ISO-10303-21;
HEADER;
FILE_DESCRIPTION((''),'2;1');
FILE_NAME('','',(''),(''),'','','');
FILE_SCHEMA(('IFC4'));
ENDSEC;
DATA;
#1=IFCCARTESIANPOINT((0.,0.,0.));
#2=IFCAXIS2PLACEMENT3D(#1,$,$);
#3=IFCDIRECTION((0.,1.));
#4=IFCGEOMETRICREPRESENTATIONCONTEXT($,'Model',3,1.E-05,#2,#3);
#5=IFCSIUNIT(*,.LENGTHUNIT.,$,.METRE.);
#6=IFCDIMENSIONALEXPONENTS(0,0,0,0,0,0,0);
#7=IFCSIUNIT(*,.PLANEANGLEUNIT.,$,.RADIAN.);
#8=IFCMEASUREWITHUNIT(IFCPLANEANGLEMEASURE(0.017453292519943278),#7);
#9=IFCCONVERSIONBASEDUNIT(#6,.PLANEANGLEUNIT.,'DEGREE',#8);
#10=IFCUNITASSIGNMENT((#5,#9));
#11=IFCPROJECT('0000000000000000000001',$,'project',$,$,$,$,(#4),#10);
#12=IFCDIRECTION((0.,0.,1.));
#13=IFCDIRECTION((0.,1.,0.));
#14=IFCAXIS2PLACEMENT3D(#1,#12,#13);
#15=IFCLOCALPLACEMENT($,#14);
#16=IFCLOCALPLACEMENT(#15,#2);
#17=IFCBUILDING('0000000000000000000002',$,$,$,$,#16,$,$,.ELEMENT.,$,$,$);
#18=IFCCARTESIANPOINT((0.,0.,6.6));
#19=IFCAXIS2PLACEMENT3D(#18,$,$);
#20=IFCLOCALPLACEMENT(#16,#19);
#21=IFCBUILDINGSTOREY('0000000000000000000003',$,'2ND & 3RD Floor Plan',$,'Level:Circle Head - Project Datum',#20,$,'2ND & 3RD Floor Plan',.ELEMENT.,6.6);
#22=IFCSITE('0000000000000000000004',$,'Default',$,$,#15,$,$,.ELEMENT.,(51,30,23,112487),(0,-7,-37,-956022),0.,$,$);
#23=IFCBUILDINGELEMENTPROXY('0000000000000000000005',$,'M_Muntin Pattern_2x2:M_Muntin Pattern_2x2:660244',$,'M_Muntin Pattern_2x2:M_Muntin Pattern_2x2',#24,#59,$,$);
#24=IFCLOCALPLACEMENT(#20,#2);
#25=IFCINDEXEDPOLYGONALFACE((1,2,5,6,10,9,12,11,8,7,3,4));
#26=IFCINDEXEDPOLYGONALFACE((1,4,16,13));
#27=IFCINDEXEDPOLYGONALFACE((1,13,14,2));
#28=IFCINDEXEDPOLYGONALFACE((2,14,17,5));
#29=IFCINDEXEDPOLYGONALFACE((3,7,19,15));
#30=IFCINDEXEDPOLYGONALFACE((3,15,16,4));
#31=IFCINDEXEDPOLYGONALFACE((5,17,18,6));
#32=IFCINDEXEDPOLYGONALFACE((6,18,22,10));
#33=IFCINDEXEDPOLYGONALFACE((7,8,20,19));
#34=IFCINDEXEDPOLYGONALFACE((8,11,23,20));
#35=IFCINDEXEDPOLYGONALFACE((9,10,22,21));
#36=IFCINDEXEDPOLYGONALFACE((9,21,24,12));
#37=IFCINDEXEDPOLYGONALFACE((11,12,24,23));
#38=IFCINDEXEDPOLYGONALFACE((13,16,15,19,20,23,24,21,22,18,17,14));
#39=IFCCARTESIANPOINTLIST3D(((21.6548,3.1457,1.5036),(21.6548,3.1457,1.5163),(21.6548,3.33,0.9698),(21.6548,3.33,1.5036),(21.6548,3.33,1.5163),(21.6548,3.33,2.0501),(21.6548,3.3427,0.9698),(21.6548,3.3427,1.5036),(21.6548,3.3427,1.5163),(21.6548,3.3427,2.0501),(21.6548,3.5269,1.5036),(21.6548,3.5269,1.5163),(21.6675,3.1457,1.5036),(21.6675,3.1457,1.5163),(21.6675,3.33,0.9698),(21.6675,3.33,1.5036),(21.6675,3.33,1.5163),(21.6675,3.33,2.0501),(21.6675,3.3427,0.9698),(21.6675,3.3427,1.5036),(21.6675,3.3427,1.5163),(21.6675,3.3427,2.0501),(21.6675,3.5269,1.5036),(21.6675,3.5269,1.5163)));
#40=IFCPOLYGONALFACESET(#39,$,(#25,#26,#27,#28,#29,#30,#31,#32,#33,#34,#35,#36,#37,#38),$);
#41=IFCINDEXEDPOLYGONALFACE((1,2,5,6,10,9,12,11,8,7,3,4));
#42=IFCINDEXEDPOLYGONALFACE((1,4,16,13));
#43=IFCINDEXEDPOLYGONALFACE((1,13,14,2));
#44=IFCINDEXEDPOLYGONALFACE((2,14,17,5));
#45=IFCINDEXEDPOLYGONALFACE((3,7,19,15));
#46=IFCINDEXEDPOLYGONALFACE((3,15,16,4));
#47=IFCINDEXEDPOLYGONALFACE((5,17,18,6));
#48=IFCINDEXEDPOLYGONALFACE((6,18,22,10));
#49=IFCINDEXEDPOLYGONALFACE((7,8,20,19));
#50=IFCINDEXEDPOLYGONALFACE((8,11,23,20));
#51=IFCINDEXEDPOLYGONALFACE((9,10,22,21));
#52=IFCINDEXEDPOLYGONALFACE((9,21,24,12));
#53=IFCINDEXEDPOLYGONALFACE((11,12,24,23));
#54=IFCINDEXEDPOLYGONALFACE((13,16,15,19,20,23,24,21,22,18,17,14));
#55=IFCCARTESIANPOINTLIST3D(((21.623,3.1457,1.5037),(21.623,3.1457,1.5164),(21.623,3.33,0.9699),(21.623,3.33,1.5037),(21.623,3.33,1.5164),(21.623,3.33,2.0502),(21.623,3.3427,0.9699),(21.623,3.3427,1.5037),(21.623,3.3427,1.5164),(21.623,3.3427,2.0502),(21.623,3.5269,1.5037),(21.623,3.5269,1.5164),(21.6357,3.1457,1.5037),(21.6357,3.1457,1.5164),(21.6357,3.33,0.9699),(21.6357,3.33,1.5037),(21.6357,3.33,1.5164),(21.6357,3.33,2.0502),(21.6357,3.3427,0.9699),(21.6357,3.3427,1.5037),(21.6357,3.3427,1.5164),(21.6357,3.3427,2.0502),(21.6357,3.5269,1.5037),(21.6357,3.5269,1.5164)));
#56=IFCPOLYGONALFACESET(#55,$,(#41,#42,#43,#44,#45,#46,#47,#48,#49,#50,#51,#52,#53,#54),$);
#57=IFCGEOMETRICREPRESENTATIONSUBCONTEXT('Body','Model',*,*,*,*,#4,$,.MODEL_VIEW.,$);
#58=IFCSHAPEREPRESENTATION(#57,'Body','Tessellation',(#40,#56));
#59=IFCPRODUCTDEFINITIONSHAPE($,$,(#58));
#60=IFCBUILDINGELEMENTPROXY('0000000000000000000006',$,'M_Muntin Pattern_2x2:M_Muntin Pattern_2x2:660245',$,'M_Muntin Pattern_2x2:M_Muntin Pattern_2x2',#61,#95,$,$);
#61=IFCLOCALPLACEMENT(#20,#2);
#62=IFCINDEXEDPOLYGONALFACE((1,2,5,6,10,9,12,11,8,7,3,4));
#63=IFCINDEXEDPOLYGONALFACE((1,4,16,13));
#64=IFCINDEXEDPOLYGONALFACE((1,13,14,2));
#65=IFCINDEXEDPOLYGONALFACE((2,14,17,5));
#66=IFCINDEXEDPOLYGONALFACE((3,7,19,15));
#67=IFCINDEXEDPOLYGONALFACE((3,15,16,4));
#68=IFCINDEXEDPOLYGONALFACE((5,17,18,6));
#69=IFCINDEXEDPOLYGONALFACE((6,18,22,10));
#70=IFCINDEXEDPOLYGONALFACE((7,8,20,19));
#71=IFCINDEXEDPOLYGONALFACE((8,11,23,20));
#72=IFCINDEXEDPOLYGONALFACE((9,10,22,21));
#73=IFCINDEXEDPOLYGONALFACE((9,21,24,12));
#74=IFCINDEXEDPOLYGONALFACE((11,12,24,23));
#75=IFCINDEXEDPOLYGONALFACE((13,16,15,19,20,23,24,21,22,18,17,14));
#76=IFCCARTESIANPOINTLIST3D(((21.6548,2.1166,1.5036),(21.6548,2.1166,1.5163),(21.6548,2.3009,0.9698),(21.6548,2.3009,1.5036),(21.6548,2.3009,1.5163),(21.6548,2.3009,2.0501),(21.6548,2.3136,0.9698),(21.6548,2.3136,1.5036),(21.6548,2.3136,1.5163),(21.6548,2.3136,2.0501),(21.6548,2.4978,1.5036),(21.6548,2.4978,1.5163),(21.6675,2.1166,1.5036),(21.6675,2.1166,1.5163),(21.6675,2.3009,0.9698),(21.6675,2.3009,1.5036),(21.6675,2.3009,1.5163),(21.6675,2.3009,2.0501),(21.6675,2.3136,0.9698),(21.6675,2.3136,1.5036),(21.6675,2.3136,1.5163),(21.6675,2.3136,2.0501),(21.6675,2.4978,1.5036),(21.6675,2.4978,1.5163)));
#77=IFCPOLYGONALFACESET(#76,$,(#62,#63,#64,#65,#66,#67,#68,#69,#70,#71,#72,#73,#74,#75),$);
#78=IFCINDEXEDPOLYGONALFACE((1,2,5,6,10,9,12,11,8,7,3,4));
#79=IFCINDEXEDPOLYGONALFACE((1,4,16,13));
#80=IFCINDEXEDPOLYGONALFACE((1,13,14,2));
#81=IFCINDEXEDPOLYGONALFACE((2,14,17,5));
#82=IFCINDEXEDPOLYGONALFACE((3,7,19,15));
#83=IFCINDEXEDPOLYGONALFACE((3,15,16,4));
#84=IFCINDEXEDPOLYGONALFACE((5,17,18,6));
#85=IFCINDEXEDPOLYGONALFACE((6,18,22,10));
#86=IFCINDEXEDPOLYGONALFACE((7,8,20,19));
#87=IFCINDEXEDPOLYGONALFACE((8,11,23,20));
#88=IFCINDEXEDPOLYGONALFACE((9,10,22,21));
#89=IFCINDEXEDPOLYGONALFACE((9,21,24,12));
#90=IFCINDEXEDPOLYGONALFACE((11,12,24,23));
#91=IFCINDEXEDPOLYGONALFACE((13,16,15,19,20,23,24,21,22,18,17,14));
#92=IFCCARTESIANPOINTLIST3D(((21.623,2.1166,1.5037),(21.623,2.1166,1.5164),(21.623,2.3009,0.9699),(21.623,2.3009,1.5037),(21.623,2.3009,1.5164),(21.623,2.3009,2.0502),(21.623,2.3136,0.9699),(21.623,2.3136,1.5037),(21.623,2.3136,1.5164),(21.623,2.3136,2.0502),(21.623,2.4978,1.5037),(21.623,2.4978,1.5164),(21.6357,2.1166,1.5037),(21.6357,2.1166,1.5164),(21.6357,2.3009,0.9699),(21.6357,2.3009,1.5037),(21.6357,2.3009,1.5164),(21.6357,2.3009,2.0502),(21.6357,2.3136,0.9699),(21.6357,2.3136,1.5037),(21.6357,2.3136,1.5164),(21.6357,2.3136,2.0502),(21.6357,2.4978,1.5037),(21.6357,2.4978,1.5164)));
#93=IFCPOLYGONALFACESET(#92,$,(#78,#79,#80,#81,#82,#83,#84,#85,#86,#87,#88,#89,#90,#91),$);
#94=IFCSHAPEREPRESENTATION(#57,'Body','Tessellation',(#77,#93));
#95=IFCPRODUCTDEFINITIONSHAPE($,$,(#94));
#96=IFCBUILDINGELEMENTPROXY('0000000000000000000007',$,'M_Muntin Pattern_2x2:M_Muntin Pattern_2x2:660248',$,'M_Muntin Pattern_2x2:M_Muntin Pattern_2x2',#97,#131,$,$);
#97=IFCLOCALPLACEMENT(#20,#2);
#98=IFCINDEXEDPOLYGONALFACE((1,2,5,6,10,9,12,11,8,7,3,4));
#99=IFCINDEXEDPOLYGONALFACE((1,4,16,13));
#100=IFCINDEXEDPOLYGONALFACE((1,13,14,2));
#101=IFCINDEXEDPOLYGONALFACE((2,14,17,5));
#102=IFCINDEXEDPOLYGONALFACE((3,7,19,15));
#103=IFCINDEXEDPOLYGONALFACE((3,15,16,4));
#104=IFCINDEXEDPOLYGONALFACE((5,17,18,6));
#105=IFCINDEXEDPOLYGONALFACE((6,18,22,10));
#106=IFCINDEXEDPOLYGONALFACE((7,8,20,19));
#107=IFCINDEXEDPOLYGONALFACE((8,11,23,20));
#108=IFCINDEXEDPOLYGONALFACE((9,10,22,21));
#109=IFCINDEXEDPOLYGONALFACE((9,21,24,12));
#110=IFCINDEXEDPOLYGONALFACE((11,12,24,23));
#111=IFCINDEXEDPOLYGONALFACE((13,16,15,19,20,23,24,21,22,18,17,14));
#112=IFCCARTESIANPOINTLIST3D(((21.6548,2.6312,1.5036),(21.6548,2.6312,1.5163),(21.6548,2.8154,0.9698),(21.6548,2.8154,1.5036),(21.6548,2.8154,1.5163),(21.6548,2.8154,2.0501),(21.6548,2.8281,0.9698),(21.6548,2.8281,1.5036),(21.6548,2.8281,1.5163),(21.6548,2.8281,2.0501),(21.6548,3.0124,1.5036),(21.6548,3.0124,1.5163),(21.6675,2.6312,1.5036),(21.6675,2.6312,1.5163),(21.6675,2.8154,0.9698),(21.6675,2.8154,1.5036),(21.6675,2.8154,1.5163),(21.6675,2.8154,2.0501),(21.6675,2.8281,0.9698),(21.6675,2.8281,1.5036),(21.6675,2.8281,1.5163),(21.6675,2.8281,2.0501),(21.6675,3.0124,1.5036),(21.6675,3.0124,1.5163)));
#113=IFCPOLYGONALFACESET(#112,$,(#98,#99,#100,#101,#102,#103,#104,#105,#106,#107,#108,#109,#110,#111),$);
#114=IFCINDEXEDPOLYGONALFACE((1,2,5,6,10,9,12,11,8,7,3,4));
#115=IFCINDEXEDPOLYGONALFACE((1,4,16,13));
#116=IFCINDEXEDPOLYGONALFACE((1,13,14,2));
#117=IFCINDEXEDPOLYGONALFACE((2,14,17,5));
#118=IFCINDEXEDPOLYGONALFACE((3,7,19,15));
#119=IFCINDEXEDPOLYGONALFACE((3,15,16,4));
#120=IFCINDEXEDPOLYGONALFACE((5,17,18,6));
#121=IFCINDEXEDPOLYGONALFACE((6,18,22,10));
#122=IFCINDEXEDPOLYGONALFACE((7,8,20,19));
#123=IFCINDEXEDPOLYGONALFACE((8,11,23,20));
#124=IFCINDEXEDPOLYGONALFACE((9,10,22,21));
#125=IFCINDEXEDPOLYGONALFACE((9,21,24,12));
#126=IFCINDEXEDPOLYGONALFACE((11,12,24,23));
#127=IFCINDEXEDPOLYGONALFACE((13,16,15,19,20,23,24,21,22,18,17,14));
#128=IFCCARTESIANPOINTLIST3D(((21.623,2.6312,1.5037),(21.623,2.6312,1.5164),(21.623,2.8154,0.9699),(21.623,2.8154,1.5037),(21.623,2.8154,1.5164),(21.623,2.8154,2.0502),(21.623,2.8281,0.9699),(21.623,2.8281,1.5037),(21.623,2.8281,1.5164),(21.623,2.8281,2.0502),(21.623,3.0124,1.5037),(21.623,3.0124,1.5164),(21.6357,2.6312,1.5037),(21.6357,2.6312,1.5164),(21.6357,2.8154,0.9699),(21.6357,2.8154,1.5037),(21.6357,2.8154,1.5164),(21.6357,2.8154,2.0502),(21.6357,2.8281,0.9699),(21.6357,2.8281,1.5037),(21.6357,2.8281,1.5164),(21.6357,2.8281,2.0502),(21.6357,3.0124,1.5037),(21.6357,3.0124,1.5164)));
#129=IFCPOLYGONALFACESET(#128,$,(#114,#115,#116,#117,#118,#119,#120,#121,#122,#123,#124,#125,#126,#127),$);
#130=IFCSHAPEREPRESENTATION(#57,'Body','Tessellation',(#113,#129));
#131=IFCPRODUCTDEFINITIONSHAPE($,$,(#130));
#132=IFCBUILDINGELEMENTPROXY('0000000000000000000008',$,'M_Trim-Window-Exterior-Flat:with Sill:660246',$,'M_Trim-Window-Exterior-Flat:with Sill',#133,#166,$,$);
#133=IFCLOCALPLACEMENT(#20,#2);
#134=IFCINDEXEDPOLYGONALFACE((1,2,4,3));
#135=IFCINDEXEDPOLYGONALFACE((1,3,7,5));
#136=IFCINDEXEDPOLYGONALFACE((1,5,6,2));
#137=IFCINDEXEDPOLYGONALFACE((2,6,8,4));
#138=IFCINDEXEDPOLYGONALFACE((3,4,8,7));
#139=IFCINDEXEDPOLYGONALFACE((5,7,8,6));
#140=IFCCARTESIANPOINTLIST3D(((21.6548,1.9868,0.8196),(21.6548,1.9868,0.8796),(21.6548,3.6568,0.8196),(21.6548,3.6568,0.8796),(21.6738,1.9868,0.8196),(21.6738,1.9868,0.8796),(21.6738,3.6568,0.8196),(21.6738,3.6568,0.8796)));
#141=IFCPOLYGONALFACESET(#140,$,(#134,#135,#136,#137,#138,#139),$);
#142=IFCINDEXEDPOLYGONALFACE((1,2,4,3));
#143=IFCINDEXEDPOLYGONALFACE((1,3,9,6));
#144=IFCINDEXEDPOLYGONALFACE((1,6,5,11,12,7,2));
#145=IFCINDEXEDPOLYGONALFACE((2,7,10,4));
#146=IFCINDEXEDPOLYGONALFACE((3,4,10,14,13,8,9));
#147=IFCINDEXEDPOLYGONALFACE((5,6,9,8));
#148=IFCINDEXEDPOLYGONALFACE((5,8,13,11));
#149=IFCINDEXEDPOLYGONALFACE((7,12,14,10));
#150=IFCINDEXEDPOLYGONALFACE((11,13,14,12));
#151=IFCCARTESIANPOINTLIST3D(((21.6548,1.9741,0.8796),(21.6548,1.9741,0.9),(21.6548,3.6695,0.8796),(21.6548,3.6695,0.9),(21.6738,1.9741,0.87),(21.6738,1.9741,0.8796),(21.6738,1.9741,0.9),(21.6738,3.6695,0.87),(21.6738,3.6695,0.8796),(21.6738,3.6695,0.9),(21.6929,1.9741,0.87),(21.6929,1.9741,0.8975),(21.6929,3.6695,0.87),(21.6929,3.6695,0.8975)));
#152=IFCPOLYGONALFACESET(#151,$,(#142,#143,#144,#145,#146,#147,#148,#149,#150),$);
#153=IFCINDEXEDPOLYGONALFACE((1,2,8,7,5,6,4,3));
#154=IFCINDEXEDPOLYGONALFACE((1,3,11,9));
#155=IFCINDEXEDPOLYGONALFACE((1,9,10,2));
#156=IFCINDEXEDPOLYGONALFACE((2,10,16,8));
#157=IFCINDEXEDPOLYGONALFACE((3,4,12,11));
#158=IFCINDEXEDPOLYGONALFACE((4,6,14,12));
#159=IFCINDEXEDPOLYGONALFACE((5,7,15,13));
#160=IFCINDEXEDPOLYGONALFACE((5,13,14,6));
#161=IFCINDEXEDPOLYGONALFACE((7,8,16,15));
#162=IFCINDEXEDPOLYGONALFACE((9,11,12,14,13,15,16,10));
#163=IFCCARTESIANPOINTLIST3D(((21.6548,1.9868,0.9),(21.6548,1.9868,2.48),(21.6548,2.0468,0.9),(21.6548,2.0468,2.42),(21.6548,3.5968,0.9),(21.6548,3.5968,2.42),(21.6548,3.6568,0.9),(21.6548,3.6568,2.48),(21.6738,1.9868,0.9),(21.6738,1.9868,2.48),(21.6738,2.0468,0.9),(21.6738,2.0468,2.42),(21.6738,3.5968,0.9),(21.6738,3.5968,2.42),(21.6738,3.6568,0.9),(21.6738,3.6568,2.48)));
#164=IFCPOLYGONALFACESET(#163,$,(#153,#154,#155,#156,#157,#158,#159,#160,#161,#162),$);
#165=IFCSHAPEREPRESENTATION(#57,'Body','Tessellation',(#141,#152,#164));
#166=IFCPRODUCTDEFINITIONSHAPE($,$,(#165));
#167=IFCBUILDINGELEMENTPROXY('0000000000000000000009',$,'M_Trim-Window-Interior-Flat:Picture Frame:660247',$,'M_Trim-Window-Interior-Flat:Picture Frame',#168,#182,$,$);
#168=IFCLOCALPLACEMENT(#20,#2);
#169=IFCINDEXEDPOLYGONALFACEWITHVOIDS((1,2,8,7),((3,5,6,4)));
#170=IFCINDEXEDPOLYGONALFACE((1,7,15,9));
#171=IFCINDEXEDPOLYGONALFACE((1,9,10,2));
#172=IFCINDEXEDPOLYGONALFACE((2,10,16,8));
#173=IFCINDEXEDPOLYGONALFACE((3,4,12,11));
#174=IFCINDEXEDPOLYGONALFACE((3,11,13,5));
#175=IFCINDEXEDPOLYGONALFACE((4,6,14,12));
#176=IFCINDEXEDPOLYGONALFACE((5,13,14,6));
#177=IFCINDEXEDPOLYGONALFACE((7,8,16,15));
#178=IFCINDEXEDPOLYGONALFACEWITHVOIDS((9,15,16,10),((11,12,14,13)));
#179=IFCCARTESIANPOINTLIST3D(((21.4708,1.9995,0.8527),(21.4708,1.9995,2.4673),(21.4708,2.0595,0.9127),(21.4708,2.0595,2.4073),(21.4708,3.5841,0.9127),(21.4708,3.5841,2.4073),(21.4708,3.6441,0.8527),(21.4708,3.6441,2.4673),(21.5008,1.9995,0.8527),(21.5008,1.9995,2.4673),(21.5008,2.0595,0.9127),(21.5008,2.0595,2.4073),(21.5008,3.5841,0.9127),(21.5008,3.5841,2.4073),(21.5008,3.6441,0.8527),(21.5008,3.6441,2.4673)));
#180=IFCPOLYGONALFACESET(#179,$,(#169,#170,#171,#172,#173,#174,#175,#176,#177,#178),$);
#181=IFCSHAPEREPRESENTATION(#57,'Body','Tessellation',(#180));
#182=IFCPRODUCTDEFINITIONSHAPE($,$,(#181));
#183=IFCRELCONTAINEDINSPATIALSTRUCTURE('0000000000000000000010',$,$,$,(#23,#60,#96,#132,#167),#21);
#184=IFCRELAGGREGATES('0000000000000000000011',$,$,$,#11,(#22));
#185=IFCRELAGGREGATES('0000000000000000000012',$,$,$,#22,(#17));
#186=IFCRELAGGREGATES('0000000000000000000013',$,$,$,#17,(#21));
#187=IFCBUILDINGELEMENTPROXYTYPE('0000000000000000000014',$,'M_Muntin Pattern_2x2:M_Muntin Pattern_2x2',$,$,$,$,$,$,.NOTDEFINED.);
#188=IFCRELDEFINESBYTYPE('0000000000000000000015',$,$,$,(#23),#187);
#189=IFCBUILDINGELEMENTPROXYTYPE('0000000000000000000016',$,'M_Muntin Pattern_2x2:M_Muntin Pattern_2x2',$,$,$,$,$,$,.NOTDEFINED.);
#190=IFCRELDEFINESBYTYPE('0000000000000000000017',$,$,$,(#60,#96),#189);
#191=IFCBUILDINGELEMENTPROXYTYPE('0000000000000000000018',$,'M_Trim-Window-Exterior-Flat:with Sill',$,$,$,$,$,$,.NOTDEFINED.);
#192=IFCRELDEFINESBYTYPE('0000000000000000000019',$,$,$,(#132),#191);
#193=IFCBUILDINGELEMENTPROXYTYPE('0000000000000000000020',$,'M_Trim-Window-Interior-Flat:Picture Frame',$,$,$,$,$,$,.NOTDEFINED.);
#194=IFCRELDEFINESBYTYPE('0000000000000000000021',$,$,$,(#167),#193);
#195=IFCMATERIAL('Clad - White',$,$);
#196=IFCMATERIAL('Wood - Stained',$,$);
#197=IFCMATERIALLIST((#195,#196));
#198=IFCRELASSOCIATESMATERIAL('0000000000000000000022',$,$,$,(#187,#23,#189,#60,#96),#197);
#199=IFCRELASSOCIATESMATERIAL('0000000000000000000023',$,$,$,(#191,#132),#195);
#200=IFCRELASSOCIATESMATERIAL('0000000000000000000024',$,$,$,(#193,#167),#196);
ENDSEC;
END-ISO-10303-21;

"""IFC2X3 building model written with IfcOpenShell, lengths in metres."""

from ifc_helpers import new_model, entity, si_unit, converted_unit, direction, frame, frame_2d, origin, place, context, subcontext, project, spatial, polyline, rectangle, outline, extrude, source, transform, mapped, material, material_list, type_object, type_shapes, element, save


model = new_model("IFC2X3")

# Units and contexts
model_context = context("Model", 3, precision=1e-05, world=origin(), true_north=direction((0.0, 1.0)))
body_context = subcontext(model_context, "Body", "Model", "MODEL_VIEW")
ifc_project = project(units=[si_unit("LENGTHUNIT", "METRE"), converted_unit("PLANEANGLEUNIT", "DEGREE", entity("IfcPlaneAngleMeasure", 0.017453292519943278), si_unit("PLANEANGLEUNIT", "RADIAN"), dimensions=[0, 0, 0, 0, 0, 0, 0])], contexts=[model_context])

# Site, building, storey
site_placement = place(None, frame((0.0, 0.0, 0.0), z_axis=(0.0, 0.0, 1.0), x_axis=(0.0, 1.0, 0.0)))
site = spatial("IfcSite", under=ifc_project, at=site_placement, Name="Default", CompositionType="ELEMENT", RefLatitude=(51, 30, 23, 112487), RefLongitude=(0, -7, -37, -956022), RefElevation=0.0)
building_placement = place(site_placement, origin())
building = spatial("IfcBuilding", under=site, at=building_placement, CompositionType="ELEMENT")
storey_placement = place(building_placement, frame((0.0, 0.0, 6.6)))
storey = spatial("IfcBuildingStorey", under=building, at=storey_placement, Name="2ND & 3RD Floor Plan", ObjectType="Level:Circle Head - Project Datum", LongName="2ND & 3RD Floor Plan", CompositionType="ELEMENT", Elevation=6.6)

# Building element proxies
ifc_material_1 = material(Name="Clad - White")
ifc_material_2 = material(Name="Wood - Stained")
ifc_material_list = material_list([ifc_material_1, ifc_material_2])
building_element_proxy_type_1 = type_object("IfcBuildingElementProxyType", Name="M_Muntin Pattern_2x2:M_Muntin Pattern_2x2", PredefinedType="NOTDEFINED", material=ifc_material_list)
shared_shape_1 = source(origin(), body_context, "Body", "SweptSolid", [
    extrude(outline(polyline([(0.0064, -0.0064), (0.5401, -0.0064), (0.5401, 0.0063), (0.0064, 0.0063), (0.0064, 0.1906), (-0.0063, 0.1906), (-0.0063, 0.0063), (-0.5402, 0.0063), (-0.5402, -0.0064), (-0.0063, -0.0064), (-0.0063, -0.1906), (0.0064, -0.1906), (0.0064, -0.0064)])), frame((0.0, 0.0095, 0.5401), z_axis=(0.0, 1.0, 0.0), x_axis=(0.0, 0.0, 1.0)), (0.0, 0.0, 1.0), 0.0127),
    extrude(outline(polyline([(0.0064, -0.0064), (0.5402, -0.0064), (0.5402, 0.0063), (0.0064, 0.0063), (0.0064, 0.1906), (-0.0063, 0.1906), (-0.0063, 0.0063), (-0.5402, 0.0063), (-0.5402, -0.0064), (-0.0063, -0.0064), (-0.0063, -0.1906), (0.0064, -0.1906), (0.0064, -0.0064)])), frame((0.0, -0.0222, 0.5402), z_axis=(0.0, 1.0, 0.0), x_axis=(0.0, 0.0, 1.0)), (0.0, 0.0, 1.0), 0.0127),
])
type_shapes(building_element_proxy_type_1, [shared_shape_1])
proxy_1_placement = place(storey_placement, frame((21.6453, 3.3363, 0.9699), z_axis=(0.0, 0.0, 1.0), x_axis=(0.0, -1.0, 0.0)))
element("IfcBuildingElementProxy", 1, at=proxy_1_placement, inside=storey, type_object=building_element_proxy_type_1, material=ifc_material_list, Name="M_Muntin Pattern_2x2:M_Muntin Pattern_2x2:660244", ObjectType="M_Muntin Pattern_2x2:M_Muntin Pattern_2x2", context=body_context, shape_type="MappedRepresentation", body=[
    mapped(shared_shape_1, transform((0.0, 0.0, 0.0), scale=1.0)),
])
building_element_proxy_type_2 = type_object("IfcBuildingElementProxyType", Name="M_Muntin Pattern_2x2:M_Muntin Pattern_2x2", PredefinedType="NOTDEFINED", material=ifc_material_list)
shared_shape_2 = source(origin(), body_context, "Body", "SweptSolid", [
    extrude(outline(polyline([(0.0064, -0.0064), (0.5401, -0.0064), (0.5401, 0.0063), (0.0064, 0.0063), (0.0064, 0.1906), (-0.0063, 0.1906), (-0.0063, 0.0063), (-0.5402, 0.0063), (-0.5402, -0.0064), (-0.0063, -0.0064), (-0.0063, -0.1906), (0.0064, -0.1906), (0.0064, -0.0064)])), frame((0.0, -0.0222, 0.5401), z_axis=(0.0, 1.0, 0.0), x_axis=(0.0, 0.0, 1.0)), (0.0, 0.0, 1.0), 0.0127),
    extrude(outline(polyline([(0.0064, -0.0064), (0.5402, -0.0064), (0.5402, 0.0063), (0.0064, 0.0063), (0.0064, 0.1906), (-0.0063, 0.1906), (-0.0063, 0.0063), (-0.5402, 0.0063), (-0.5402, -0.0064), (-0.0063, -0.0064), (-0.0063, -0.1906), (0.0064, -0.1906), (0.0064, -0.0064)])), frame((0.0, 0.0095, 0.5402), z_axis=(0.0, 1.0, 0.0), x_axis=(0.0, 0.0, 1.0)), (0.0, 0.0, 1.0), 0.0127),
])
type_shapes(building_element_proxy_type_2, [shared_shape_2])
for number, where, z_axis, x_axis, name in (
    (2, (21.6453, 2.3072, 0.9699), (0.0, 0.0, 1.0), (0.0, 1.0, 0.0), "M_Muntin Pattern_2x2:M_Muntin Pattern_2x2:660245"),
    (3, (21.6453, 2.8218, 0.9699), (0.0, 0.0, 1.0), (0.0, 1.0, 0.0), "M_Muntin Pattern_2x2:M_Muntin Pattern_2x2:660248"),
):
    element("IfcBuildingElementProxy", number, at=place(storey_placement, frame(where, z_axis=z_axis, x_axis=x_axis)), inside=storey, type_object=building_element_proxy_type_2, material=ifc_material_list, Name=name, ObjectType="M_Muntin Pattern_2x2:M_Muntin Pattern_2x2", context=body_context, shape_type="MappedRepresentation", body=[
        mapped(shared_shape_2, transform((0.0, 0.0, 0.0), scale=1.0)),
    ])
building_element_proxy_type_3 = type_object("IfcBuildingElementProxyType", Name="M_Trim-Window-Exterior-Flat:with Sill", PredefinedType="NOTDEFINED", material=ifc_material_1)
shared_shape_3 = source(origin(), body_context, "Body", "SweptSolid", [
    extrude(rectangle(XDim=1.67, YDim=0.06, at=frame_2d((0.0, 0.0), x_axis=(1.0, 0.0))), frame((0.0, -1.5704, 0.0), z_axis=(0.0, 0.0, 1.0), x_axis=(-1.0, 0.0, 0.0)), (0.0, 0.0, 1.0), 0.019),
    extrude(outline(polyline([(-0.019, -0.0152), (0.0, -0.0152), (0.0, -0.0057), (0.019, -0.0057), (0.019, 0.0148), (0.0, 0.0148), (-0.019, 0.0123), (-0.019, -0.0152)])), frame((-0.8477, -1.5348, 0.019), z_axis=(1.0, 0.0, 0.0), x_axis=(0.0, 0.0, -1.0)), (0.0, 0.0, 1.0), 1.6954),
    extrude(outline(polyline([(-0.805, -0.835), (0.775, -0.835), (0.775, -0.775), (-0.745, -0.775), (-0.745, 0.775), (0.775, 0.775), (0.775, 0.835), (-0.805, 0.835), (-0.805, -0.835)])), frame((0.0, -0.745, 0.0), z_axis=(0.0, 0.0, 1.0), x_axis=(0.0, -1.0, 0.0)), (0.0, 0.0, 1.0), 0.019),
])
type_shapes(building_element_proxy_type_3, [shared_shape_3])
proxy_2_placement = place(storey_placement, frame((21.6548, 2.8218, 2.42), z_axis=(1.0, 0.0, 0.0), x_axis=(0.0, 1.0, 0.0)))
element("IfcBuildingElementProxy", 4, at=proxy_2_placement, inside=storey, type_object=building_element_proxy_type_3, material=ifc_material_1, Name="M_Trim-Window-Exterior-Flat:with Sill:660246", ObjectType="M_Trim-Window-Exterior-Flat:with Sill", context=body_context, shape_type="MappedRepresentation", body=[
    mapped(shared_shape_3, transform((0.0, 0.0, 0.0), scale=1.0)),
])
building_element_proxy_type_4 = type_object("IfcBuildingElementProxyType", Name="M_Trim-Window-Interior-Flat:Picture Frame", PredefinedType="NOTDEFINED", material=ifc_material_2)
shared_shape_4 = source(origin(), body_context, "Body", "SweptSolid", [
    extrude(outline(polyline([(-0.8223, -0.8073), (0.8223, -0.8073), (0.8223, 0.8073), (-0.8223, 0.8073), (-0.8223, -0.8073)]), holes=[polyline([(-0.7623, -0.7473), (-0.7623, 0.7473), (0.7623, 0.7473), (0.7623, -0.7473), (-0.7623, -0.7473)])]), frame((0.0, -0.76, 0.0), z_axis=(0.0, 0.0, 1.0), x_axis=(-1.0, 0.0, 0.0)), (0.0, 0.0, 1.0), 0.03),
])
type_shapes(building_element_proxy_type_4, [shared_shape_4])
proxy_3_placement = place(storey_placement, frame((21.5008, 2.8218, 2.42), z_axis=(-1.0, 0.0, 0.0), x_axis=(0.0, -1.0, 0.0)))
element("IfcBuildingElementProxy", 5, at=proxy_3_placement, inside=storey, type_object=building_element_proxy_type_4, material=ifc_material_2, Name="M_Trim-Window-Interior-Flat:Picture Frame:660247", ObjectType="M_Trim-Window-Interior-Flat:Picture Frame", context=body_context, shape_type="MappedRepresentation", body=[
    mapped(shared_shape_4, transform((0.0, 0.0, 0.0), scale=1.0)),
])

save(model, "model.ifc")
